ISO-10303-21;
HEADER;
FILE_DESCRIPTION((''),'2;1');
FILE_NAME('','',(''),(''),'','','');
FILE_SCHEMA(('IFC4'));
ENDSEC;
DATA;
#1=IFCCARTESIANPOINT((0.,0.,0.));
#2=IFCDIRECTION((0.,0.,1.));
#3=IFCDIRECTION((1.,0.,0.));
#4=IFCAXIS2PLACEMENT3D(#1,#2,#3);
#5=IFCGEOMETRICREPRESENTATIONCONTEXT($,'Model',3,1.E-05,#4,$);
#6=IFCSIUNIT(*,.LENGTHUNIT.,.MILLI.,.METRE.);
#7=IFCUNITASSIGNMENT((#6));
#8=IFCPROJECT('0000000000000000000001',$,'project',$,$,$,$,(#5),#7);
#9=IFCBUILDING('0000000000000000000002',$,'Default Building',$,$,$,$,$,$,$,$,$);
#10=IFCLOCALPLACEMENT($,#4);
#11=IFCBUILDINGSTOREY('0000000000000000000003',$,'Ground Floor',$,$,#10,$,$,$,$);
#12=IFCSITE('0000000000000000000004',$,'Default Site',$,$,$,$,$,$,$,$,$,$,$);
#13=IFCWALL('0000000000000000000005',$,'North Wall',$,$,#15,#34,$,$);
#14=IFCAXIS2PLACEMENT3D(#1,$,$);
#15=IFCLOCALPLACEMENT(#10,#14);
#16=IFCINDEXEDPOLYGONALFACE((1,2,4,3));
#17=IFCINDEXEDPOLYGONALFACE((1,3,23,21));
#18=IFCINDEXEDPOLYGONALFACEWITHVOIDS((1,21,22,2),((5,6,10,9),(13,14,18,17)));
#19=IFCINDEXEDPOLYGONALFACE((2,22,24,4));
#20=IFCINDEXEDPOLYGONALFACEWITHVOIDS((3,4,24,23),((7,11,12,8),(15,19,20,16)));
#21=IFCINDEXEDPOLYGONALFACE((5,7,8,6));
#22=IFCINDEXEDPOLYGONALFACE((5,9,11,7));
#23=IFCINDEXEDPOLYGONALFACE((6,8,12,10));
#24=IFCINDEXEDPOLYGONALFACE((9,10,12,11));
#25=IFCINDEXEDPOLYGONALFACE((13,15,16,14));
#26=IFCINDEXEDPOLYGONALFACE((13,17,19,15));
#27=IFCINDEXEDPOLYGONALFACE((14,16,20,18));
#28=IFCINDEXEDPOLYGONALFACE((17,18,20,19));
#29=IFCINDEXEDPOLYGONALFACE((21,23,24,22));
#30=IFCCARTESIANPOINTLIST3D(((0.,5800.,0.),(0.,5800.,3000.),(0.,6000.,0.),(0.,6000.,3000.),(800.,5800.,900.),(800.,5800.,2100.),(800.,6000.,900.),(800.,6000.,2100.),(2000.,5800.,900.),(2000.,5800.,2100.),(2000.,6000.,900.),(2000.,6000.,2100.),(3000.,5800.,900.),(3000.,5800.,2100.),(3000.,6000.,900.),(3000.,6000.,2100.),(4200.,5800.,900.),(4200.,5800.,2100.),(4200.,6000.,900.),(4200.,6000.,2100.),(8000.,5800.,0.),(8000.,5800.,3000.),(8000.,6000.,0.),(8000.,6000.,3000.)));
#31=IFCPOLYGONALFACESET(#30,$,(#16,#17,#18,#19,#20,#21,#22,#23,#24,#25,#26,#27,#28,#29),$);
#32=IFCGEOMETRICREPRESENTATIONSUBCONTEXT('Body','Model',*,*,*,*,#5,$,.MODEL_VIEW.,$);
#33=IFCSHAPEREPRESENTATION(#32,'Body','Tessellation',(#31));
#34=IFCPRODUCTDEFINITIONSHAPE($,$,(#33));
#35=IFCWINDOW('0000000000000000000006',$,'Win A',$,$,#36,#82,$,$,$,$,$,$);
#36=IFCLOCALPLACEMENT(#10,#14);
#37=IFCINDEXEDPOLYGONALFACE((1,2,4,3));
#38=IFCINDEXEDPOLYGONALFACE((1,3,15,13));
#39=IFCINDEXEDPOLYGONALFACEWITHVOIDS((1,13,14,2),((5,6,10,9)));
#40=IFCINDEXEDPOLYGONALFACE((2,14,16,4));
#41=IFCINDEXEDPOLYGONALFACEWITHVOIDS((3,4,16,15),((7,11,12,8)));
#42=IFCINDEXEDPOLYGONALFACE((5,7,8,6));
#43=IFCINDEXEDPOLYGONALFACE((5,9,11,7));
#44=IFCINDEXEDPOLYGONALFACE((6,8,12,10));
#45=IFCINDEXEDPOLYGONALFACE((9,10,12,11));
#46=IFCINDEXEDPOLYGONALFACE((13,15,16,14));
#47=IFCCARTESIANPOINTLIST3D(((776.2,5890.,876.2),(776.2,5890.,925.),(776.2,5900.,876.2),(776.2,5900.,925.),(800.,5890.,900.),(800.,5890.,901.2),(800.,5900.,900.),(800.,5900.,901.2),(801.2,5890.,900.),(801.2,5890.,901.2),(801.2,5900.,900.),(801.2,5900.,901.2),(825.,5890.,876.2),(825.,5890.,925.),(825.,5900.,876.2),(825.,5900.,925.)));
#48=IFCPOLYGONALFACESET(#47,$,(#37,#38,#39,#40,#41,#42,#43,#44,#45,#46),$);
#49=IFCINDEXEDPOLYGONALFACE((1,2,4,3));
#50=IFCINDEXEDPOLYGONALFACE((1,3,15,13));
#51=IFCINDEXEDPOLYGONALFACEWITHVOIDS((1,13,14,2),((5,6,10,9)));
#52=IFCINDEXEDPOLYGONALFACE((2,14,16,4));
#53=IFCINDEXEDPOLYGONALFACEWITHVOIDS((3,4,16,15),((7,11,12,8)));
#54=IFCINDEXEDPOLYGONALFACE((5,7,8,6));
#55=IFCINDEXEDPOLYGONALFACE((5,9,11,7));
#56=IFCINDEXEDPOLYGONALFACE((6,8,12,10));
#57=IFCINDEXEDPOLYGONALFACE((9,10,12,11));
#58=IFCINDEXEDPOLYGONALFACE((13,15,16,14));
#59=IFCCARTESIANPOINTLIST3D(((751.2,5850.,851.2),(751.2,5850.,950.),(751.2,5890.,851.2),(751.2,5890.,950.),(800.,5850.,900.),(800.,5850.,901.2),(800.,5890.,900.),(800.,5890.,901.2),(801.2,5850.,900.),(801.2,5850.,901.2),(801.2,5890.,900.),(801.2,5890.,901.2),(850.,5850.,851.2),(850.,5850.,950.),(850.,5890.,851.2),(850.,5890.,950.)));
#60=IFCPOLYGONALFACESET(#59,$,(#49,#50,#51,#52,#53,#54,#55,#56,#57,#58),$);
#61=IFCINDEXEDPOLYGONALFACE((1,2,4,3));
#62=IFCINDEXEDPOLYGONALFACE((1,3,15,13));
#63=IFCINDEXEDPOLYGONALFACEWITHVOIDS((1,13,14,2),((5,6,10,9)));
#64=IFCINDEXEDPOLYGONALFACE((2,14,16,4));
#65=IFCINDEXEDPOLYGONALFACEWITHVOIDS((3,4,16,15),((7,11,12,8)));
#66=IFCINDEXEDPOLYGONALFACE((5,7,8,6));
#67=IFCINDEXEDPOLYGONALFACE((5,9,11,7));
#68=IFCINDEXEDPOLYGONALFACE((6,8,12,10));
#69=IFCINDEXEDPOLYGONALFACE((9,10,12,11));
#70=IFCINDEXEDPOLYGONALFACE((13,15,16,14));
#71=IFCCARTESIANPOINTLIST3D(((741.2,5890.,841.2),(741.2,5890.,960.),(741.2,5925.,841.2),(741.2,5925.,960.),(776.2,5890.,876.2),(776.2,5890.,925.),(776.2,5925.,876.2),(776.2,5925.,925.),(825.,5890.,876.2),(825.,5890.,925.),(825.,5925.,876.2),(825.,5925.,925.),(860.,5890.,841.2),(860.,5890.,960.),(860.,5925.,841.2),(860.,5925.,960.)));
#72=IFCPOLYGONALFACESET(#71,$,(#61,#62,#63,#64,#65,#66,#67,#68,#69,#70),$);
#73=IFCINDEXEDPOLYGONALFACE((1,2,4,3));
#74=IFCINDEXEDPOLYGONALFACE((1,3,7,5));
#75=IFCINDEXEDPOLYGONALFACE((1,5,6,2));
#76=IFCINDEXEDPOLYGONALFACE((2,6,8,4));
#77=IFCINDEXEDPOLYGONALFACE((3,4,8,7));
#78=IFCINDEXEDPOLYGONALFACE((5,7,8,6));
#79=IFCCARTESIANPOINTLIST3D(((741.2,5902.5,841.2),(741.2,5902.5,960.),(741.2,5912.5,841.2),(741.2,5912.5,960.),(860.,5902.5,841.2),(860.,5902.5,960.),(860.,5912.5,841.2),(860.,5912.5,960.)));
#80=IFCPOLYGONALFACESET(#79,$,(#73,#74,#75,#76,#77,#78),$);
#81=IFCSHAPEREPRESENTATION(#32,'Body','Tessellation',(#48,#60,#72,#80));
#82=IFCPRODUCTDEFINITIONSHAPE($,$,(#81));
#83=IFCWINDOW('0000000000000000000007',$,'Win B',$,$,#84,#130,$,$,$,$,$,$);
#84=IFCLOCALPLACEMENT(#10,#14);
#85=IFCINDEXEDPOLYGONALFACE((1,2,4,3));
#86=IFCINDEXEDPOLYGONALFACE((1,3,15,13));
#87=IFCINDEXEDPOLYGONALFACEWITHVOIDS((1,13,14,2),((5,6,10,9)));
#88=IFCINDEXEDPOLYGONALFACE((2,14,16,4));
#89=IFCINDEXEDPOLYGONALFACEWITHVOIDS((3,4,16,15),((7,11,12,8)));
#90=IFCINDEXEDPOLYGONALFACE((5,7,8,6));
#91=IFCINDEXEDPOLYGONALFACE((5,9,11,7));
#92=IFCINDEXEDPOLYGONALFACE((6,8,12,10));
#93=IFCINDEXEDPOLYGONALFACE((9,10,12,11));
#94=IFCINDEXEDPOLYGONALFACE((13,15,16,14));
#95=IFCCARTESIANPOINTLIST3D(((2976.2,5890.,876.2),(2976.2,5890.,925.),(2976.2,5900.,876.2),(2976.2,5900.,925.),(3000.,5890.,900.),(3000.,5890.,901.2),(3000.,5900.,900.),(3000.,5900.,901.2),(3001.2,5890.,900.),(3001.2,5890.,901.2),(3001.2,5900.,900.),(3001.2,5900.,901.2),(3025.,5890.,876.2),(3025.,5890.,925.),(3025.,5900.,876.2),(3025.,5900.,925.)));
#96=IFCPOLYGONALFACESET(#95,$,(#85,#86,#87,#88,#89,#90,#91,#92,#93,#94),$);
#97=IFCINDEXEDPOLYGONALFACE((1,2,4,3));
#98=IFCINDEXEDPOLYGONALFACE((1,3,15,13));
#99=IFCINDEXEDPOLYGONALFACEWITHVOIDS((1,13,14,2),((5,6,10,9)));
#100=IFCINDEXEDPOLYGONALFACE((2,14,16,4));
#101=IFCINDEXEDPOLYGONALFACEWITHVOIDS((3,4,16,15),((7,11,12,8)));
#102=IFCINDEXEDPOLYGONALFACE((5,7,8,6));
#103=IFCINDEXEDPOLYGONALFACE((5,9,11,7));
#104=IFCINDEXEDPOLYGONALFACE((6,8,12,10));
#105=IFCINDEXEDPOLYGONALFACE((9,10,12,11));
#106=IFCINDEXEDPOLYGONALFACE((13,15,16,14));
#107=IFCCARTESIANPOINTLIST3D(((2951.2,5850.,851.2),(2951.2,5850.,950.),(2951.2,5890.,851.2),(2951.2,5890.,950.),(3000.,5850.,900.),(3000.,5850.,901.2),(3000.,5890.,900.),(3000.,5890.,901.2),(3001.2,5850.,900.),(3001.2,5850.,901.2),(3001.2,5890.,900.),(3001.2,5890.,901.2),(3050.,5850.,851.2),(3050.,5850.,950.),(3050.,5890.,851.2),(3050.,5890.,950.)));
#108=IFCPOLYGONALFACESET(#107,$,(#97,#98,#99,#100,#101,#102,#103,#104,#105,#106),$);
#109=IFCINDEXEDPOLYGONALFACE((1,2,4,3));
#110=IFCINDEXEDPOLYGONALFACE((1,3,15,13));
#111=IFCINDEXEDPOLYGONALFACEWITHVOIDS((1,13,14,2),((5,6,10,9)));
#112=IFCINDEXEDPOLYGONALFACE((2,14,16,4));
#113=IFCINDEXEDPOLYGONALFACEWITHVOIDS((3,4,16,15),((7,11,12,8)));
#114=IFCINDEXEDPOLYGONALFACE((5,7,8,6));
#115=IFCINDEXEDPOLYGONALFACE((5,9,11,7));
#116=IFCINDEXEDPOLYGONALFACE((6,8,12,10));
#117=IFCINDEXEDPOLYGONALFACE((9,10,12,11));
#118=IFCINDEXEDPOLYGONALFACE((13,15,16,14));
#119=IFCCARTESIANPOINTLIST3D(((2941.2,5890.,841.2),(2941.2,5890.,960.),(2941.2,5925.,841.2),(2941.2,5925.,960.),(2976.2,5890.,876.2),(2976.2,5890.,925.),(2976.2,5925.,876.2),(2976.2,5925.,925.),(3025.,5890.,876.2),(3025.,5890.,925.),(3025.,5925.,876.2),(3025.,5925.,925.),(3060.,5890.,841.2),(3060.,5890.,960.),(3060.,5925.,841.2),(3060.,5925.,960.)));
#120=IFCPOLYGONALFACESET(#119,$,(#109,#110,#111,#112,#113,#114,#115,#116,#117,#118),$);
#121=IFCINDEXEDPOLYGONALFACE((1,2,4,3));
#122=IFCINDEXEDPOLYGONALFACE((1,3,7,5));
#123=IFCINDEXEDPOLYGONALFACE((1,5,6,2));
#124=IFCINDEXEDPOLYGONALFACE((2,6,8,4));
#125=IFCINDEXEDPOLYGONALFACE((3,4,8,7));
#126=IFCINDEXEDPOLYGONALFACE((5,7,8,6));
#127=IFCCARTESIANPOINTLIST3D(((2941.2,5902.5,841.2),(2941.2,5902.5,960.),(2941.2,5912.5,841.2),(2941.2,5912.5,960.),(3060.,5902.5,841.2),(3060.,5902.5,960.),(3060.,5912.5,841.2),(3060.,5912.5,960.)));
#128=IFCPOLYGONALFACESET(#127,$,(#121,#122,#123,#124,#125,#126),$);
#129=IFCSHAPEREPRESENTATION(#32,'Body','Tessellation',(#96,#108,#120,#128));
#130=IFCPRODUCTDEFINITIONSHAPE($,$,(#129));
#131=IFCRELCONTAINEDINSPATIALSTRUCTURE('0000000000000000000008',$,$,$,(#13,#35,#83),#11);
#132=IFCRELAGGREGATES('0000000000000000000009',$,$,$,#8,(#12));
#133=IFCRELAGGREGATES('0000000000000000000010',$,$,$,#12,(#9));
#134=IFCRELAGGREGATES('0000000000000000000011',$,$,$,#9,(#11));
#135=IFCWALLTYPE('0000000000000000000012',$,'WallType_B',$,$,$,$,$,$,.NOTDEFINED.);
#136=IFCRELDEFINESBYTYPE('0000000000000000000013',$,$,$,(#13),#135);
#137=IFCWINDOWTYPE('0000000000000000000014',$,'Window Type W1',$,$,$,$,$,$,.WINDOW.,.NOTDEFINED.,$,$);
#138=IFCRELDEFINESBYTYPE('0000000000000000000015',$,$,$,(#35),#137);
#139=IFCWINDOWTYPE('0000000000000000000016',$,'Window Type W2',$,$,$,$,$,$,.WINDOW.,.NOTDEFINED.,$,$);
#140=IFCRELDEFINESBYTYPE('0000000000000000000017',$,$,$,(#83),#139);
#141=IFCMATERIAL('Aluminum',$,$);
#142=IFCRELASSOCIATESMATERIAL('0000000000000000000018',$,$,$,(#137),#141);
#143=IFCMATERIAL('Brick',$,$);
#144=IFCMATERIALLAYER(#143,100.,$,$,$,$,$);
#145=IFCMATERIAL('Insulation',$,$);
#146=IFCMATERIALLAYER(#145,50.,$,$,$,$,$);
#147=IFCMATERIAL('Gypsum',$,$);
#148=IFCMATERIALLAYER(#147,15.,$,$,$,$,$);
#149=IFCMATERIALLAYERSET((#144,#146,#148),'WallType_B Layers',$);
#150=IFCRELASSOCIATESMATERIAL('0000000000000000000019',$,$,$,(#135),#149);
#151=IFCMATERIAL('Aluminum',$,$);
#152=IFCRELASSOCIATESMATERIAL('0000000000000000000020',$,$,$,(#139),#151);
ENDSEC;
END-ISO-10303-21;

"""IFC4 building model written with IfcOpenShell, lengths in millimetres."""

from ifc_helpers import new_model, si_unit, frame, origin_with_axes, place, context, subcontext, project, spatial, line, indexed_curve, outline, extrude, material, layer, layer_set, type_object, element, fill, save


model = new_model("IFC4")

# Units and contexts
model_context = context("Model", 3, precision=1e-05, world=origin_with_axes())
body_context = subcontext(model_context, "Body", "Model", "MODEL_VIEW")
ifc_project = project(units=[si_unit("LENGTHUNIT", "METRE", prefix="MILLI")], contexts=[model_context])

# Site, building, storey
site = spatial("IfcSite", under=ifc_project, Name="Default Site")
building = spatial("IfcBuilding", under=site, Name="Default Building")
storey_placement = place(None, origin_with_axes())
storey = spatial("IfcBuildingStorey", under=building, at=storey_placement, Name="Ground Floor")

# Shared definitions
ifc_material_1 = material(Name="Aluminum")
window_type_1 = type_object("IfcWindowType", Name="Window Type W1", PartitioningType="NOTDEFINED", PredefinedType="WINDOW", material=ifc_material_1)

# Wall, openings, windows
ifc_material_2 = material(Name="Brick")
ifc_layer_1 = layer(ifc_material_2, 100.0)
ifc_material_3 = material(Name="Insulation")
ifc_layer_2 = layer(ifc_material_3, 50.0)
ifc_material_4 = material(Name="Gypsum")
ifc_layer_3 = layer(ifc_material_4, 15.0)
ifc_layer_set_1 = layer_set([ifc_layer_1, ifc_layer_2, ifc_layer_3], Name="WallType_B Layers")
wall_type_1 = type_object("IfcWallType", Name="WallType_B", PredefinedType="NOTDEFINED", material=ifc_layer_set_1)
wall_1_placement = place(storey_placement, origin_with_axes())
wall_1 = element("IfcWall", 1, at=wall_1_placement, inside=storey, type_object=wall_type_1, Name="North Wall", context=body_context, shape_type="SweptSolid", body=[
    extrude(outline(indexed_curve([(0.0, 5800.0), (8000.0, 5800.0), (8000.0, 6000.0), (0.0, 6000.0), (0.0, 5800.0)])), None, (0.0, 0.0, 1.0), 3000.0),
])
opening_1_placement = place(wall_1_placement, frame((0.0, 0.0, 900.0), z_axis=(0.0, 0.0, 1.0), x_axis=(1.0, 0.0, 0.0)))
opening_1 = element("IfcOpeningElement", 2, at=opening_1_placement, cuts=wall_1, context=body_context, shape_type="SweptSolid", body=[
    extrude(outline(indexed_curve([(800.0, 5800.0), (2000.0, 5800.0), (2000.0, 6000.0), (800.0, 6000.0), (800.0, 5800.0)])), None, (0.0, 0.0, 1.0), 1200.0),
])
opening_2_placement = place(wall_1_placement, frame((0.0, 0.0, 900.0), z_axis=(0.0, 0.0, 1.0), x_axis=(1.0, 0.0, 0.0)))
opening_2 = element("IfcOpeningElement", 3, at=opening_2_placement, cuts=wall_1, context=body_context, shape_type="SweptSolid", body=[
    extrude(outline(indexed_curve([(3000.0, 5800.0), (4200.0, 5800.0), (4200.0, 6000.0), (3000.0, 6000.0), (3000.0, 5800.0)])), None, (0.0, 0.0, 1.0), 1200.0),
])
window_1_placement = place(storey_placement, frame((800.0, 5800.0, 900.0), z_axis=(0.0, 0.0, 1.0), x_axis=(1.0, 0.0, 0.0)))
window_1 = element("IfcWindow", 4, at=window_1_placement, inside=storey, type_object=window_type_1, Name="Win A", context=body_context, shape_type="SweptSolid", body=[
    extrude(outline(indexed_curve([(0.0, 0.0), (1.2, 0.0), (1.2, 1.2), (0.0, 1.2)], segments=[line(1, 2, 3, 4, 1)]), holes=[indexed_curve([(25.0, 25.0), (-23.8, 25.0), (-23.8, -23.8), (25.0, -23.8)], segments=[line(1, 2, 3, 4, 1)])]), frame((0.0, 90.0, 0.0), z_axis=(0.0, -1.0, 0.0), x_axis=(1.0, 0.0, 0.0)), (0.0, 0.0, -1.0), 10.0),
    extrude(outline(indexed_curve([(0.0, 0.0), (1.2, 0.0), (1.2, 1.2), (0.0, 1.2)], segments=[line(1, 2, 3, 4, 1)]), holes=[indexed_curve([(50.0, 50.0), (-48.8, 50.0), (-48.8, -48.8), (50.0, -48.8)], segments=[line(1, 2, 3, 4, 1)])]), frame((0.0, 50.0, 0.0), z_axis=(0.0, -1.0, 0.0), x_axis=(1.0, 0.0, 0.0)), (0.0, 0.0, -1.0), 40.0),
    extrude(outline(indexed_curve([(0.0, 0.0), (-48.8, 0.0), (-48.8, -48.8), (0.0, -48.8)], segments=[line(1, 2, 3, 4, 1)]), holes=[indexed_curve([(35.0, 35.0), (-83.8, 35.0), (-83.8, -83.8), (35.0, -83.8)], segments=[line(1, 2, 3, 4, 1)])]), frame((25.0, 90.0, 25.0), z_axis=(0.0, -1.0, 0.0), x_axis=(1.0, 0.0, 0.0)), (0.0, 0.0, -1.0), 35.0),
    extrude(outline(indexed_curve([(35.0, 35.0), (-83.8, 35.0), (-83.8, -83.8), (35.0, -83.8)], segments=[line(1, 2, 3, 4, 1)])), frame((25.0, 102.5, 25.0), z_axis=(0.0, -1.0, 0.0), x_axis=(1.0, 0.0, 0.0)), (0.0, 0.0, -1.0), 10.0),
])
fill(opening_1, window_1)
ifc_material_5 = material(Name="Aluminum")
window_type_2 = type_object("IfcWindowType", Name="Window Type W2", PartitioningType="NOTDEFINED", PredefinedType="WINDOW", material=ifc_material_5)
window_2_placement = place(storey_placement, frame((3000.0, 5800.0, 900.0), z_axis=(0.0, 0.0, 1.0), x_axis=(1.0, 0.0, 0.0)))
window_2 = element("IfcWindow", 5, at=window_2_placement, inside=storey, type_object=window_type_2, Name="Win B", context=body_context, shape_type="SweptSolid", body=[
    extrude(outline(indexed_curve([(0.0, 0.0), (1.2, 0.0), (1.2, 1.2), (0.0, 1.2)], segments=[line(1, 2, 3, 4, 1)]), holes=[indexed_curve([(25.0, 25.0), (-23.8, 25.0), (-23.8, -23.8), (25.0, -23.8)], segments=[line(1, 2, 3, 4, 1)])]), frame((0.0, 90.0, 0.0), z_axis=(0.0, -1.0, 0.0), x_axis=(1.0, 0.0, 0.0)), (0.0, 0.0, -1.0), 10.0),
    extrude(outline(indexed_curve([(0.0, 0.0), (1.2, 0.0), (1.2, 1.2), (0.0, 1.2)], segments=[line(1, 2, 3, 4, 1)]), holes=[indexed_curve([(50.0, 50.0), (-48.8, 50.0), (-48.8, -48.8), (50.0, -48.8)], segments=[line(1, 2, 3, 4, 1)])]), frame((0.0, 50.0, 0.0), z_axis=(0.0, -1.0, 0.0), x_axis=(1.0, 0.0, 0.0)), (0.0, 0.0, -1.0), 40.0),
    extrude(outline(indexed_curve([(0.0, 0.0), (-48.8, 0.0), (-48.8, -48.8), (0.0, -48.8)], segments=[line(1, 2, 3, 4, 1)]), holes=[indexed_curve([(35.0, 35.0), (-83.8, 35.0), (-83.8, -83.8), (35.0, -83.8)], segments=[line(1, 2, 3, 4, 1)])]), frame((25.0, 90.0, 25.0), z_axis=(0.0, -1.0, 0.0), x_axis=(1.0, 0.0, 0.0)), (0.0, 0.0, -1.0), 35.0),
    extrude(outline(indexed_curve([(35.0, 35.0), (-83.8, 35.0), (-83.8, -83.8), (35.0, -83.8)], segments=[line(1, 2, 3, 4, 1)])), frame((25.0, 102.5, 25.0), z_axis=(0.0, -1.0, 0.0), x_axis=(1.0, 0.0, 0.0)), (0.0, 0.0, -1.0), 10.0),
])
fill(opening_2, window_2)

save(model, "model.ifc")
